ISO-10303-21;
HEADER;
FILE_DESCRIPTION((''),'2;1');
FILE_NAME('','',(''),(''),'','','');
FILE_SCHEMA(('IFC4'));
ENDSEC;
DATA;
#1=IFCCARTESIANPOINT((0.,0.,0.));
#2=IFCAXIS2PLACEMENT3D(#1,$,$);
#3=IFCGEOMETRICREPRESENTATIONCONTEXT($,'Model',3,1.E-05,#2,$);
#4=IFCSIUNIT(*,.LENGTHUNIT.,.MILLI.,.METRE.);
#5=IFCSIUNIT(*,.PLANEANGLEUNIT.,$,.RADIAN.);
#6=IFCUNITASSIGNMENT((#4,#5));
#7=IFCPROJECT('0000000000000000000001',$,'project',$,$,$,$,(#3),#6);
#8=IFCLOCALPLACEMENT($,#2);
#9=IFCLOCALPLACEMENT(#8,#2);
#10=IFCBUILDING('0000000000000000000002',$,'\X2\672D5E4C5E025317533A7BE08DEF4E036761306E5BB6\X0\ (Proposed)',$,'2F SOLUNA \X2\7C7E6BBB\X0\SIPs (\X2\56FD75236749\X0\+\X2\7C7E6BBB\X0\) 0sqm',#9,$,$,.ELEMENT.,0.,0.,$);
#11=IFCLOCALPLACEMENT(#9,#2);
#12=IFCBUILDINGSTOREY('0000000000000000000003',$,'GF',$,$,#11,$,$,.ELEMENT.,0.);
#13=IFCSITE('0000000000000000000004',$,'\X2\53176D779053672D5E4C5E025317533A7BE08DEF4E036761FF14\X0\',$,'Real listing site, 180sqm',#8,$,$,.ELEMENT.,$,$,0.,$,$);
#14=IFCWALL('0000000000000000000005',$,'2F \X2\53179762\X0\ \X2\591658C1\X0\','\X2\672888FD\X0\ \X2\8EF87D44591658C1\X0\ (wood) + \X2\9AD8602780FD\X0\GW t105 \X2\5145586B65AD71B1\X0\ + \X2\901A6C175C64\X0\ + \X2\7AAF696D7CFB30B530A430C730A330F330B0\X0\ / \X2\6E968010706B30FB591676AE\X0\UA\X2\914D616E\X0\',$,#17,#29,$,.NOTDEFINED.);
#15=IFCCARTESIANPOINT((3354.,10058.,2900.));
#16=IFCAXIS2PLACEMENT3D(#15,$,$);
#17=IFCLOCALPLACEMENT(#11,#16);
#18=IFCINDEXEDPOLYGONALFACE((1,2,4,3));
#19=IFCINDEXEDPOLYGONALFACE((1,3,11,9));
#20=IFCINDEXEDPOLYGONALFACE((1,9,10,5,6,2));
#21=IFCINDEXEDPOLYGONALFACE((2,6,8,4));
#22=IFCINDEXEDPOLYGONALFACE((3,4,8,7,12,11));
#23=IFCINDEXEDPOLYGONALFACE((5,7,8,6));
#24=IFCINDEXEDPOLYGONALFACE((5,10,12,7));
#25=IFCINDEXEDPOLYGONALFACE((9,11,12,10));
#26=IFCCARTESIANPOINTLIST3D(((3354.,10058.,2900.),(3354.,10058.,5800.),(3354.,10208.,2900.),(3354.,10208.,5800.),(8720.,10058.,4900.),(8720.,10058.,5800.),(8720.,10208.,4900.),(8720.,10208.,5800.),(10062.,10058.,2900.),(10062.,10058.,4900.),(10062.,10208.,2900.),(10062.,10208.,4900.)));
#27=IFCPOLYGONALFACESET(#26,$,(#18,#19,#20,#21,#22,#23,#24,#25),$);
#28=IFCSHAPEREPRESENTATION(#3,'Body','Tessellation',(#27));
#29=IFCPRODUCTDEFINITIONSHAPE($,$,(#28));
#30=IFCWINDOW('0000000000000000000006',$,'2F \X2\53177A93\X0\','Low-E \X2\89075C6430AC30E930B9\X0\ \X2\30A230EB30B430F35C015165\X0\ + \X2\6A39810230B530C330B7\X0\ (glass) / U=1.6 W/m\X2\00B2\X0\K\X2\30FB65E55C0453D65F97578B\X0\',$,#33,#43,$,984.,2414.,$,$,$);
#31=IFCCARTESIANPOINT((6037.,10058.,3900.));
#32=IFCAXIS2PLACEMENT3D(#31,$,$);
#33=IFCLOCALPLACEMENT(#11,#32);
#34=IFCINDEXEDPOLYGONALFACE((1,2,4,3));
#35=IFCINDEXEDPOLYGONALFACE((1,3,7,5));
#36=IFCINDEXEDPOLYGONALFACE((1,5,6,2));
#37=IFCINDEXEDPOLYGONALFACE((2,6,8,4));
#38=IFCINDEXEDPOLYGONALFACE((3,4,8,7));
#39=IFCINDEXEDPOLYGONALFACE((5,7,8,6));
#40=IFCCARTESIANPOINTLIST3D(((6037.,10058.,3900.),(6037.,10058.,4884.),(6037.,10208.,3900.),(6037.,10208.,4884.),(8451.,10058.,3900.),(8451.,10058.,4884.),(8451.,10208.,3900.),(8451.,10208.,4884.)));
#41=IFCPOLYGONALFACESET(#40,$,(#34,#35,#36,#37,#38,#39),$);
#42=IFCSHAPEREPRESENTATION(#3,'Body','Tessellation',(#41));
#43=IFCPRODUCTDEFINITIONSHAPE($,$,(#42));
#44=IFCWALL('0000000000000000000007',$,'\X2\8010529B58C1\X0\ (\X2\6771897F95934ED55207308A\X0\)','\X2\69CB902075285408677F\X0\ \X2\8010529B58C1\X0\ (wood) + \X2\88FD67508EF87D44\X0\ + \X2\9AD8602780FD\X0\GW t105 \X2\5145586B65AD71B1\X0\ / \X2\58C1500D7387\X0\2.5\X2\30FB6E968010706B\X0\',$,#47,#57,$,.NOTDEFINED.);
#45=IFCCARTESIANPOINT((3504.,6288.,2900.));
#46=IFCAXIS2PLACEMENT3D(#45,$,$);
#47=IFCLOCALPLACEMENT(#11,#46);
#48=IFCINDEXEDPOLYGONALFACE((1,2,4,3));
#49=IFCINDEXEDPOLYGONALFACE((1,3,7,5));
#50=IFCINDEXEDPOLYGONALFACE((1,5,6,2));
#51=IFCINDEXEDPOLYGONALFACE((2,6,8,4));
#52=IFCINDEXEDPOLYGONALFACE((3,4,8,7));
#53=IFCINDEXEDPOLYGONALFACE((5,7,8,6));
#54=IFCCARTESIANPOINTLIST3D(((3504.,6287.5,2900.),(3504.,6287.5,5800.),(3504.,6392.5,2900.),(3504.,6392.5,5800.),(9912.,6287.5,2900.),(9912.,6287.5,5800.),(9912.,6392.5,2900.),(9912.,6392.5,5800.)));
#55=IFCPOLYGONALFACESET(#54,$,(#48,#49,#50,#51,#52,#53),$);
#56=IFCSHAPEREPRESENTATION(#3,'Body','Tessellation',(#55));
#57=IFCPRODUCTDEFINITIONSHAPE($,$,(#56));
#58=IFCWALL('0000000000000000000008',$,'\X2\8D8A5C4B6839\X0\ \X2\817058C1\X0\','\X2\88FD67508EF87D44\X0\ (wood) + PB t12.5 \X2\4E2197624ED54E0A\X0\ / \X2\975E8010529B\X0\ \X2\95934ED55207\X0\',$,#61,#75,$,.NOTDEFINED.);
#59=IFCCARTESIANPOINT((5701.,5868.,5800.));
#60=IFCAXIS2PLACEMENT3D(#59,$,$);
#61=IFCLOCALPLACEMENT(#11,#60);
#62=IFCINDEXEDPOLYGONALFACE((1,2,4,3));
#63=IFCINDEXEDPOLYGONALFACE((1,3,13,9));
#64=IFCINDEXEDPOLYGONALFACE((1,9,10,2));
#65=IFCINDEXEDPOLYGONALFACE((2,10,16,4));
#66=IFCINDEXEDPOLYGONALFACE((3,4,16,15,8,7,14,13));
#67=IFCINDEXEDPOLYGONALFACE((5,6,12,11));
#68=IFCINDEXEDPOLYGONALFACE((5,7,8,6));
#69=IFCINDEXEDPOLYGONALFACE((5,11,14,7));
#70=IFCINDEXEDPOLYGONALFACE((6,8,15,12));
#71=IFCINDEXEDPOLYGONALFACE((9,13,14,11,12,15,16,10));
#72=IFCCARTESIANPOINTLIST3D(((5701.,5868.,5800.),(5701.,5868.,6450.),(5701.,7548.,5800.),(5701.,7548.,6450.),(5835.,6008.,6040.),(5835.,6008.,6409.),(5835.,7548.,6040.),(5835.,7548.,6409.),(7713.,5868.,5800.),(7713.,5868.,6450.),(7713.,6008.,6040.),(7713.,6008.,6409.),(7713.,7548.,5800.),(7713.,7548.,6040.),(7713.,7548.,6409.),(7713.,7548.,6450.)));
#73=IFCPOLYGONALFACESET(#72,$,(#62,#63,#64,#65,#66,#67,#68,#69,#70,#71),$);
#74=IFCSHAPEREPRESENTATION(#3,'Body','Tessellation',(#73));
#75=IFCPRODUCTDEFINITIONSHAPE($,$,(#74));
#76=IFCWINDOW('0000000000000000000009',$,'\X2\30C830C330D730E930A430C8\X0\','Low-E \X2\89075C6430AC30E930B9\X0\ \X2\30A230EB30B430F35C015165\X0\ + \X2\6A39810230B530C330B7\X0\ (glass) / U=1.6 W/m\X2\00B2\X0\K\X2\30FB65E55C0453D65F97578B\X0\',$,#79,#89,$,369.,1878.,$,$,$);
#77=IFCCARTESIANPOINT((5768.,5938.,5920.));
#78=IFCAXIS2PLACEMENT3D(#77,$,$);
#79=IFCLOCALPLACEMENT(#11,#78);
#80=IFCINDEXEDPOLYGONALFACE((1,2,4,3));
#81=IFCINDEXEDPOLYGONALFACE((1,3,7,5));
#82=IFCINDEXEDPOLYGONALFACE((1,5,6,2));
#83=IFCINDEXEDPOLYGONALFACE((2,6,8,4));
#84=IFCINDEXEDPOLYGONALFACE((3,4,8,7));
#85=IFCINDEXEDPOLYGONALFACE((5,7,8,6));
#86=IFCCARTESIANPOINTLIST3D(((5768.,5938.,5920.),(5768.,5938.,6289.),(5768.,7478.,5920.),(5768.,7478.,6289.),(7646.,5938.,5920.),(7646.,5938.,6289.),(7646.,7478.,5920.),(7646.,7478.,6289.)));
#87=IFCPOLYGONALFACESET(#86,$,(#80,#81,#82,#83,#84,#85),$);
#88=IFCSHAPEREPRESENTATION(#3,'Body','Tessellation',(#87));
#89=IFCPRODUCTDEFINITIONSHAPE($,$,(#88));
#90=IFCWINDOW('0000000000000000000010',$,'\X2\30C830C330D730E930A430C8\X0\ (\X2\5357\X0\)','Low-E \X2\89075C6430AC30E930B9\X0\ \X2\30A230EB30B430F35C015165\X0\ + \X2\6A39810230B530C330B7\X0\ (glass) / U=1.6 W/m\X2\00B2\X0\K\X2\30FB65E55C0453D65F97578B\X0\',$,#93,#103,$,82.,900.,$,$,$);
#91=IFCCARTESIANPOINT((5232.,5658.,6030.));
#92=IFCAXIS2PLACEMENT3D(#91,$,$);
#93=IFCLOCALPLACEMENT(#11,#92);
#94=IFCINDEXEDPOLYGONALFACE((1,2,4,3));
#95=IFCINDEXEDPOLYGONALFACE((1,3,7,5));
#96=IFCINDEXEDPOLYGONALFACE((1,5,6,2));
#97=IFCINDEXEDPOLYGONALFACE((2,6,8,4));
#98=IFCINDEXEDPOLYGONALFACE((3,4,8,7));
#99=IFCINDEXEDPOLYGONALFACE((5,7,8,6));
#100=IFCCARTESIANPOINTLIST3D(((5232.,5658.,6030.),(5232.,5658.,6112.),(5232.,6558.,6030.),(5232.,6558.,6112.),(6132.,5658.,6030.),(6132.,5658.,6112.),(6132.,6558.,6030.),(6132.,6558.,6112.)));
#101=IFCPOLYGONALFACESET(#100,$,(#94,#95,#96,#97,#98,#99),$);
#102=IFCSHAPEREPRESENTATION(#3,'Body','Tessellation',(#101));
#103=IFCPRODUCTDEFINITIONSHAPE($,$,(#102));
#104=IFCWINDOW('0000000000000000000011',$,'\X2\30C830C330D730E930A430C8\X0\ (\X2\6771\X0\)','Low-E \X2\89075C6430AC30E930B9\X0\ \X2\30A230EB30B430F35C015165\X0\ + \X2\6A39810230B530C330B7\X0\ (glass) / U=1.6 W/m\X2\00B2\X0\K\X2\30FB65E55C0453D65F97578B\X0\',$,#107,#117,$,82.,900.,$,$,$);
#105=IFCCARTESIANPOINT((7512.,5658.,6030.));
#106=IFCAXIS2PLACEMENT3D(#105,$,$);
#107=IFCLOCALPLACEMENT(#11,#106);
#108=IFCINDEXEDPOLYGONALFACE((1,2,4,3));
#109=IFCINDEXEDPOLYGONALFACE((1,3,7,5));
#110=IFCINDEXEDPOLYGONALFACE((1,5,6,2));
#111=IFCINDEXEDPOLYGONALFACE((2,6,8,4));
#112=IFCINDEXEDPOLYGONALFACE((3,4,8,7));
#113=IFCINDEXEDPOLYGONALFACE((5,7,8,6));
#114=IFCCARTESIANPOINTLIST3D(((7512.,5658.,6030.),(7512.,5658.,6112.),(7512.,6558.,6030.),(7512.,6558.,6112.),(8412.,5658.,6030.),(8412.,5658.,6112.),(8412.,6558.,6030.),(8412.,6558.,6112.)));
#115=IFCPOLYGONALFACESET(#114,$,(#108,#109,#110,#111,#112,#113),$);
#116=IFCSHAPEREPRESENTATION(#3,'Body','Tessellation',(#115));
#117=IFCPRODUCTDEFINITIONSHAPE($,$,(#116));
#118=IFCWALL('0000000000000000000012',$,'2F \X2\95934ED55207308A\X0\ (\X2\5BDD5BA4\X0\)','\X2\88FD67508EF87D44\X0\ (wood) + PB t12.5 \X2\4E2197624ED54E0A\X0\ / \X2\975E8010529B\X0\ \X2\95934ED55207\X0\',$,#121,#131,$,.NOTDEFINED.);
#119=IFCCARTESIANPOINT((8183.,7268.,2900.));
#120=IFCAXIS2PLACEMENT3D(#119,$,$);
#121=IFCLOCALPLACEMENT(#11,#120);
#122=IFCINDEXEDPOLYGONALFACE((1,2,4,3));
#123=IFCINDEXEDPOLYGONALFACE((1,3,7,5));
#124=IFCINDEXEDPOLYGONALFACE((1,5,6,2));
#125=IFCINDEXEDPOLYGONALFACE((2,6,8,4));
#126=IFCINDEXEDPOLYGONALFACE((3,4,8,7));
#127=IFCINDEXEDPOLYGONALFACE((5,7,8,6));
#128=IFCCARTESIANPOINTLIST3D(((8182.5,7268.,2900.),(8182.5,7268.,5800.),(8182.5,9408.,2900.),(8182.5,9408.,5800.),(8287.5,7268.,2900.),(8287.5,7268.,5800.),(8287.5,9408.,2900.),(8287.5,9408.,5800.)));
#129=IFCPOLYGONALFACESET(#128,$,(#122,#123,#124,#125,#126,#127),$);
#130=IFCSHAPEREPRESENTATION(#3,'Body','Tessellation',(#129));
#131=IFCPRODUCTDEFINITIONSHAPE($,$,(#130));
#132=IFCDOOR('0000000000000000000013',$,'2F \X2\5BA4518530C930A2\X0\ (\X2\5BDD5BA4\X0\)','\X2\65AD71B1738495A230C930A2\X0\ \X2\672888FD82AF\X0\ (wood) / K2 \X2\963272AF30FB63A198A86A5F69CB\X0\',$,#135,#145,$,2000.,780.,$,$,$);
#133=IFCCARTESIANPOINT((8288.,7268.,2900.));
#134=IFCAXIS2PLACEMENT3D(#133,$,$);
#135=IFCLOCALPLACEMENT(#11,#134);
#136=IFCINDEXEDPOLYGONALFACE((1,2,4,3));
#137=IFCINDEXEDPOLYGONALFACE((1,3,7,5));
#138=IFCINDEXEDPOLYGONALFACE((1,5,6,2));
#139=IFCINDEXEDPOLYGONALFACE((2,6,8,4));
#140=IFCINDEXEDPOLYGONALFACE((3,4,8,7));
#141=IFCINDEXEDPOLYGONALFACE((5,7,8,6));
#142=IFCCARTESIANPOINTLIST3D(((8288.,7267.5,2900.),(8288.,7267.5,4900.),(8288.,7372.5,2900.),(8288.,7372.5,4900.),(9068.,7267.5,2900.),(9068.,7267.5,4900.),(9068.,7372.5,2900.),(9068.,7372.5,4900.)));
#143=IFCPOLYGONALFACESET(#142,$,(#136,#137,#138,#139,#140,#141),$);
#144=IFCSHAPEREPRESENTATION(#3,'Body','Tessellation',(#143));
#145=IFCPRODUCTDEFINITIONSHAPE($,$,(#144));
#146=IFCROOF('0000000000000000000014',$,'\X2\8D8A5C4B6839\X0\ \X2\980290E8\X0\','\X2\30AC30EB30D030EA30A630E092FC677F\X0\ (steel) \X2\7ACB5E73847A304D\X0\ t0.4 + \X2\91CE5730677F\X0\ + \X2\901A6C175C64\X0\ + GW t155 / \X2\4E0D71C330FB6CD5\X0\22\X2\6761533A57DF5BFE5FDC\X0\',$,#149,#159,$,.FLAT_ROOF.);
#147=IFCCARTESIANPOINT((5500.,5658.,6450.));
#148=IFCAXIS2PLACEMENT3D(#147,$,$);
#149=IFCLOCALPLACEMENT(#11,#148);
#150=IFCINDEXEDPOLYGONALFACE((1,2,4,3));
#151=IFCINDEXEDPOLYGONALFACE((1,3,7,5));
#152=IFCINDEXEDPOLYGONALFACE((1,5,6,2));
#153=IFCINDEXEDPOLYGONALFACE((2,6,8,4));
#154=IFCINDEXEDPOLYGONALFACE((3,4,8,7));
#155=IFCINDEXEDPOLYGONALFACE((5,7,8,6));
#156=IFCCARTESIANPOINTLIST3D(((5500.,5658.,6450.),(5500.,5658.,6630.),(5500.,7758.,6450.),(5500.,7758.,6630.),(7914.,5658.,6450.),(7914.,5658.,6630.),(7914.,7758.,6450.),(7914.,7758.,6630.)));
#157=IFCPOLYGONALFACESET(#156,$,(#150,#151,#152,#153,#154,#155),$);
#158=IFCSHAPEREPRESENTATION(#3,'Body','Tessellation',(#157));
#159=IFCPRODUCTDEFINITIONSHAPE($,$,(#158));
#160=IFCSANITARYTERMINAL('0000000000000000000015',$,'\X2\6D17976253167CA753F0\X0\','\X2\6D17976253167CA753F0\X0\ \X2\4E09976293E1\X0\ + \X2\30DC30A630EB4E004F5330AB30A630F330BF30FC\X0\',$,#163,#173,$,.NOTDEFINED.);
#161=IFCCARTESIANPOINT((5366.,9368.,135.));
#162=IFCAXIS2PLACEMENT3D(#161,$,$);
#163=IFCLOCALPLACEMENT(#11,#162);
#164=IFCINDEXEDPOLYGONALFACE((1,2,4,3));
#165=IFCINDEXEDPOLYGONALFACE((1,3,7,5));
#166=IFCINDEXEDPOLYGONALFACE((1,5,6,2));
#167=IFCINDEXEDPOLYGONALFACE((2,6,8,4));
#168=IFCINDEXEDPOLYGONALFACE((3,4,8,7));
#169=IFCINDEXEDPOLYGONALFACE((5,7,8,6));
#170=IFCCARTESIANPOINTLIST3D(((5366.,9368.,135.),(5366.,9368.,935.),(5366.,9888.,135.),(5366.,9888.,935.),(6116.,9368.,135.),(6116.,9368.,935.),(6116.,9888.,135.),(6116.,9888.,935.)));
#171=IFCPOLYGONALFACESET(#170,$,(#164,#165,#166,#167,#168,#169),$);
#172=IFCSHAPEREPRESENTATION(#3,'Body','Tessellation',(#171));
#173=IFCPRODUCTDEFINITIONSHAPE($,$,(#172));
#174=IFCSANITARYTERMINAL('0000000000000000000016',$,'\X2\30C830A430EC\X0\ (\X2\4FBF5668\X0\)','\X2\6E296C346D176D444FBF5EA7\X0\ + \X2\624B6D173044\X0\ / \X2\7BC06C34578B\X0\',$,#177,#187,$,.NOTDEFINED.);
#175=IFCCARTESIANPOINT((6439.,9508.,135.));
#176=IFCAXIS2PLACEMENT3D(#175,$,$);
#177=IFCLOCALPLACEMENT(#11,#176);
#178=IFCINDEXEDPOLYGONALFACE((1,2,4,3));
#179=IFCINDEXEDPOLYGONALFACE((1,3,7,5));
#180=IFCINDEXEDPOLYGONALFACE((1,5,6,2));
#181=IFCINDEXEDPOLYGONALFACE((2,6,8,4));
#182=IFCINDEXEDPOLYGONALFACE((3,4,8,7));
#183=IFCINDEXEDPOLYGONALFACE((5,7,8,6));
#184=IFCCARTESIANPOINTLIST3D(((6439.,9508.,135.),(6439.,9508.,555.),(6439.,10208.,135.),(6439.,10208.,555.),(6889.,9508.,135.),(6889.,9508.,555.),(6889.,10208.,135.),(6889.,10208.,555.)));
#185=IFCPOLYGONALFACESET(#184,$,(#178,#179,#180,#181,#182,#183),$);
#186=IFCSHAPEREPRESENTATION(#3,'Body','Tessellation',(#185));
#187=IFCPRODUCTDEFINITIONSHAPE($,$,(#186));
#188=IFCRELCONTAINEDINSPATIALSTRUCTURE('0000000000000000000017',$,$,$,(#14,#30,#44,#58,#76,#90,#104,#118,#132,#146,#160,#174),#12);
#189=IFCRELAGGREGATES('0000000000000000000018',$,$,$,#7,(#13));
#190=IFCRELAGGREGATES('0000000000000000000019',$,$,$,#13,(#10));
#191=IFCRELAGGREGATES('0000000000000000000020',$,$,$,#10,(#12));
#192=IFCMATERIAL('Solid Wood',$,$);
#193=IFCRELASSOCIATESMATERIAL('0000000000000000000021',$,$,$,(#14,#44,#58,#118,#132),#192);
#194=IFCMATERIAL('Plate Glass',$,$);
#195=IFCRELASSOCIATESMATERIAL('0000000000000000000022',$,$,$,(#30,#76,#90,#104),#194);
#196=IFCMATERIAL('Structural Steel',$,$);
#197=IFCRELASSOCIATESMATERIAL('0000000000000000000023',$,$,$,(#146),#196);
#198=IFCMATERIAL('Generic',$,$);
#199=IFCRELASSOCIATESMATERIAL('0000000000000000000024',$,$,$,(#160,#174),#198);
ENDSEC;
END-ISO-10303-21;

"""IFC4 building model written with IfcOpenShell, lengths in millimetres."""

from ifc_helpers import new_model, si_unit, frame, frame_2d, origin, place, context, project, spatial, rectangle, extrude, material, element, fill, save


model = new_model("IFC4")

# Units and contexts
model_context = context("Model", 3, precision=1e-05, world=origin())
ifc_project = project(units=[si_unit("LENGTHUNIT", "METRE", prefix="MILLI"), si_unit("PLANEANGLEUNIT", "RADIAN")], contexts=[model_context])

# Site, building, storey
site_placement = place(None, origin())
site = spatial("IfcSite", under=ifc_project, at=site_placement, Name="北海道札幌市北区篠路七条４", ObjectType="Real listing site, 180sqm", CompositionType="ELEMENT", RefElevation=0.0)
building_placement = place(site_placement, origin())
building = spatial("IfcBuilding", under=site, at=building_placement, Name="札幌市北区篠路七条の家 (Proposed)", ObjectType="2F SOLUNA 籾殻SIPs (国産杉+籾殻) 0sqm", CompositionType="ELEMENT", ElevationOfRefHeight=0.0, ElevationOfTerrain=0.0)
storey_placement = place(building_placement, origin())
storey = spatial("IfcBuildingStorey", under=building, at=storey_placement, Name="GF", CompositionType="ELEMENT", Elevation=0.0)

# Wall, opening, window
ifc_material_1 = material(Name="Solid Wood")
wall_1_placement = place(storey_placement, frame((3354.0, 10058.0, 2900.0)))
wall_1 = element("IfcWall", 1, at=wall_1_placement, inside=storey, material=ifc_material_1, Name="2F 北面 外壁", Description="木製 軸組外壁 (wood) + 高性能GW t105 充填断熱 + 通気層 + 窯業系サイディング / 準耐火・外皮UA配慮", PredefinedType="NOTDEFINED", context=model_context, shape_type="SweptSolid", body=[
    extrude(rectangle(XDim=6708.0, YDim=150.0, at=frame_2d((3354.0, 75.0))), frame((3354.0, 10058.0, 2900.0)), (0.0, 0.0, 1.0), 2900.0),
])
opening_1_placement = place(storey_placement, frame((6037.0, 10058.0, 3900.0)))
opening_1 = element("IfcOpeningElement", 2, at=opening_1_placement, cuts=wall_1, PredefinedType="NOTDEFINED", context=model_context, shape_type="SweptSolid", body=[
    extrude(rectangle(XDim=2414.0, YDim=150.0, at=frame_2d((1207.0, 75.0))), frame((6037.0, 10058.0, 3900.0)), (0.0, 0.0, 1.0), 984.0),
])
ifc_material_2 = material(Name="Plate Glass")
window_1_placement = place(storey_placement, frame((6037.0, 10058.0, 3900.0)))
window_1 = element("IfcWindow", 3, at=window_1_placement, inside=storey, material=ifc_material_2, Name="2F 北窓", Description="Low-E 複層ガラス アルゴン封入 + 樹脂サッシ (glass) / U=1.6 W/m²K・日射取得型", OverallHeight=984.0, OverallWidth=2414.0, context=model_context, shape_type="SweptSolid", body=[
    extrude(rectangle(XDim=2414.0, YDim=150.0, at=frame_2d((1207.0, 75.0))), frame((6037.0, 10058.0, 3900.0)), (0.0, 0.0, 1.0), 984.0),
])
fill(opening_1, window_1)

# Wall
wall_2_placement = place(storey_placement, frame((3504.0, 6288.0, 2900.0)))
element("IfcWall", 4, at=wall_2_placement, inside=storey, material=ifc_material_1, Name="耐力壁 (東西間仕切り)", Description="構造用合板 耐力壁 (wood) + 製材軸組 + 高性能GW t105 充填断熱 / 壁倍率2.5・準耐火", PredefinedType="NOTDEFINED", context=model_context, shape_type="SweptSolid", body=[
    extrude(rectangle(XDim=6408.0, YDim=105.0, at=frame_2d((3204.0, 52.0))), frame((3504.0, 6288.0, 2900.0)), (0.0, 0.0, 1.0), 2900.0),
])

# Wall, openings, windows
wall_3_placement = place(storey_placement, frame((5701.0, 5868.0, 5800.0)))
wall_3 = element("IfcWall", 5, at=wall_3_placement, inside=storey, material=ifc_material_1, Name="越屋根 腰壁", Description="製材軸組 (wood) + PB t12.5 両面仕上 / 非耐力 間仕切", PredefinedType="NOTDEFINED", context=model_context, shape_type="SweptSolid", body=[
    extrude(rectangle(XDim=2012.0, YDim=1680.0, at=frame_2d((1006.0, 840.0))), frame((5701.0, 5868.0, 5800.0)), (0.0, 0.0, 1.0), 650.0),
])
opening_2_placement = place(storey_placement, frame((5768.0, 5938.0, 5920.0)))
opening_2 = element("IfcOpeningElement", 6, at=opening_2_placement, cuts=wall_3, PredefinedType="NOTDEFINED", context=model_context, shape_type="SweptSolid", body=[
    extrude(rectangle(XDim=1878.0, YDim=1540.0, at=frame_2d((939.0, 770.0))), frame((5768.0, 5938.0, 5920.0)), (0.0, 0.0, 1.0), 369.0),
])
opening_3_placement = place(storey_placement, frame((5232.0, 5658.0, 6030.0)))
opening_3 = element("IfcOpeningElement", 7, at=opening_3_placement, cuts=wall_3, PredefinedType="NOTDEFINED", context=model_context, shape_type="SweptSolid", body=[
    extrude(rectangle(XDim=900.0, YDim=900.0, at=frame_2d((450.0, 450.0))), frame((5232.0, 5658.0, 6030.0)), (0.0, 0.0, 1.0), 82.0),
])
opening_4_placement = place(storey_placement, frame((7512.0, 5658.0, 6030.0)))
opening_4 = element("IfcOpeningElement", 8, at=opening_4_placement, cuts=wall_3, PredefinedType="NOTDEFINED", context=model_context, shape_type="SweptSolid", body=[
    extrude(rectangle(XDim=900.0, YDim=900.0, at=frame_2d((450.0, 450.0))), frame((7512.0, 5658.0, 6030.0)), (0.0, 0.0, 1.0), 82.0),
])
window_2_placement = place(storey_placement, frame((5768.0, 5938.0, 5920.0)))
window_2 = element("IfcWindow", 9, at=window_2_placement, inside=storey, material=ifc_material_2, Name="トップライト", Description="Low-E 複層ガラス アルゴン封入 + 樹脂サッシ (glass) / U=1.6 W/m²K・日射取得型", OverallHeight=369.0, OverallWidth=1878.0, context=model_context, shape_type="SweptSolid", body=[
    extrude(rectangle(XDim=1878.0, YDim=1540.0, at=frame_2d((939.0, 770.0))), frame((5768.0, 5938.0, 5920.0)), (0.0, 0.0, 1.0), 369.0),
])
fill(opening_2, window_2)
window_3_placement = place(storey_placement, frame((5232.0, 5658.0, 6030.0)))
window_3 = element("IfcWindow", 10, at=window_3_placement, inside=storey, material=ifc_material_2, Name="トップライト (南)", Description="Low-E 複層ガラス アルゴン封入 + 樹脂サッシ (glass) / U=1.6 W/m²K・日射取得型", OverallHeight=82.0, OverallWidth=900.0, context=model_context, shape_type="SweptSolid", body=[
    extrude(rectangle(XDim=900.0, YDim=900.0, at=frame_2d((450.0, 450.0))), frame((5232.0, 5658.0, 6030.0)), (0.0, 0.0, 1.0), 82.0),
])
fill(opening_3, window_3)
window_4_placement = place(storey_placement, frame((7512.0, 5658.0, 6030.0)))
window_4 = element("IfcWindow", 11, at=window_4_placement, inside=storey, material=ifc_material_2, Name="トップライト (東)", Description="Low-E 複層ガラス アルゴン封入 + 樹脂サッシ (glass) / U=1.6 W/m²K・日射取得型", OverallHeight=82.0, OverallWidth=900.0, context=model_context, shape_type="SweptSolid", body=[
    extrude(rectangle(XDim=900.0, YDim=900.0, at=frame_2d((450.0, 450.0))), frame((7512.0, 5658.0, 6030.0)), (0.0, 0.0, 1.0), 82.0),
])
fill(opening_4, window_4)

# Wall
wall_4_placement = place(storey_placement, frame((8183.0, 7268.0, 2900.0)))
element("IfcWall", 12, at=wall_4_placement, inside=storey, material=ifc_material_1, Name="2F 間仕切り (寝室)", Description="製材軸組 (wood) + PB t12.5 両面仕上 / 非耐力 間仕切", PredefinedType="NOTDEFINED", context=model_context, shape_type="SweptSolid", body=[
    extrude(rectangle(XDim=105.0, YDim=2140.0, at=frame_2d((52.0, 1070.0))), frame((8183.0, 7268.0, 2900.0)), (0.0, 0.0, 1.0), 2900.0),
])

# Door
door_placement = place(storey_placement, frame((8288.0, 7268.0, 2900.0)))
element("IfcDoor", 13, at=door_placement, inside=storey, material=ifc_material_1, Name="2F 室内ドア (寝室)", Description="断熱玄関ドア 木製芯 (wood) / K2 防犯・採風機構", OverallHeight=2000.0, OverallWidth=780.0, context=model_context, shape_type="SweptSolid", body=[
    extrude(rectangle(XDim=780.0, YDim=105.0, at=frame_2d((390.0, 52.0))), frame((8288.0, 7268.0, 2900.0)), (0.0, 0.0, 1.0), 2000.0),
])

# Roof
ifc_material_3 = material(Name="Structural Steel")
roof_placement = place(storey_placement, frame((5500.0, 5658.0, 6450.0)))
element("IfcRoof", 14, at=roof_placement, inside=storey, material=ifc_material_3, Name="越屋根 頂部", Description="ガルバリウム鋼板 (steel) 立平葺き t0.4 + 野地板 + 通気層 + GW t155 / 不燃・法22条区域対応", PredefinedType="FLAT_ROOF", context=model_context, shape_type="SweptSolid", body=[
    extrude(rectangle(XDim=2414.0, YDim=2100.0, at=frame_2d((1207.0, 1050.0))), frame((5500.0, 5658.0, 6450.0)), (0.0, 0.0, 1.0), 180.0),
])

# Sanitary terminals
ifc_material_4 = material(Name="Generic")
sanitary_terminal_1_placement = place(storey_placement, frame((5366.0, 9368.0, 135.0)))
element("IfcSanitaryTerminal", 15, at=sanitary_terminal_1_placement, inside=storey, material=ifc_material_4, Name="洗面化粧台", Description="洗面化粧台 三面鏡 + ボウル一体カウンター", PredefinedType="NOTDEFINED", context=model_context, shape_type="SweptSolid", body=[
    extrude(rectangle(XDim=750.0, YDim=520.0, at=frame_2d((375.0, 260.0))), frame((5366.0, 9368.0, 135.0)), (0.0, 0.0, 1.0), 800.0),
])
sanitary_terminal_2_placement = place(storey_placement, frame((6439.0, 9508.0, 135.0)))
element("IfcSanitaryTerminal", 16, at=sanitary_terminal_2_placement, inside=storey, material=ifc_material_4, Name="トイレ (便器)", Description="温水洗浄便座 + 手洗い / 節水型", PredefinedType="NOTDEFINED", context=model_context, shape_type="SweptSolid", body=[
    extrude(rectangle(XDim=450.0, YDim=700.0, at=frame_2d((225.0, 350.0))), frame((6439.0, 9508.0, 135.0)), (0.0, 0.0, 1.0), 420.0),
])

save(model, "model.ifc")
